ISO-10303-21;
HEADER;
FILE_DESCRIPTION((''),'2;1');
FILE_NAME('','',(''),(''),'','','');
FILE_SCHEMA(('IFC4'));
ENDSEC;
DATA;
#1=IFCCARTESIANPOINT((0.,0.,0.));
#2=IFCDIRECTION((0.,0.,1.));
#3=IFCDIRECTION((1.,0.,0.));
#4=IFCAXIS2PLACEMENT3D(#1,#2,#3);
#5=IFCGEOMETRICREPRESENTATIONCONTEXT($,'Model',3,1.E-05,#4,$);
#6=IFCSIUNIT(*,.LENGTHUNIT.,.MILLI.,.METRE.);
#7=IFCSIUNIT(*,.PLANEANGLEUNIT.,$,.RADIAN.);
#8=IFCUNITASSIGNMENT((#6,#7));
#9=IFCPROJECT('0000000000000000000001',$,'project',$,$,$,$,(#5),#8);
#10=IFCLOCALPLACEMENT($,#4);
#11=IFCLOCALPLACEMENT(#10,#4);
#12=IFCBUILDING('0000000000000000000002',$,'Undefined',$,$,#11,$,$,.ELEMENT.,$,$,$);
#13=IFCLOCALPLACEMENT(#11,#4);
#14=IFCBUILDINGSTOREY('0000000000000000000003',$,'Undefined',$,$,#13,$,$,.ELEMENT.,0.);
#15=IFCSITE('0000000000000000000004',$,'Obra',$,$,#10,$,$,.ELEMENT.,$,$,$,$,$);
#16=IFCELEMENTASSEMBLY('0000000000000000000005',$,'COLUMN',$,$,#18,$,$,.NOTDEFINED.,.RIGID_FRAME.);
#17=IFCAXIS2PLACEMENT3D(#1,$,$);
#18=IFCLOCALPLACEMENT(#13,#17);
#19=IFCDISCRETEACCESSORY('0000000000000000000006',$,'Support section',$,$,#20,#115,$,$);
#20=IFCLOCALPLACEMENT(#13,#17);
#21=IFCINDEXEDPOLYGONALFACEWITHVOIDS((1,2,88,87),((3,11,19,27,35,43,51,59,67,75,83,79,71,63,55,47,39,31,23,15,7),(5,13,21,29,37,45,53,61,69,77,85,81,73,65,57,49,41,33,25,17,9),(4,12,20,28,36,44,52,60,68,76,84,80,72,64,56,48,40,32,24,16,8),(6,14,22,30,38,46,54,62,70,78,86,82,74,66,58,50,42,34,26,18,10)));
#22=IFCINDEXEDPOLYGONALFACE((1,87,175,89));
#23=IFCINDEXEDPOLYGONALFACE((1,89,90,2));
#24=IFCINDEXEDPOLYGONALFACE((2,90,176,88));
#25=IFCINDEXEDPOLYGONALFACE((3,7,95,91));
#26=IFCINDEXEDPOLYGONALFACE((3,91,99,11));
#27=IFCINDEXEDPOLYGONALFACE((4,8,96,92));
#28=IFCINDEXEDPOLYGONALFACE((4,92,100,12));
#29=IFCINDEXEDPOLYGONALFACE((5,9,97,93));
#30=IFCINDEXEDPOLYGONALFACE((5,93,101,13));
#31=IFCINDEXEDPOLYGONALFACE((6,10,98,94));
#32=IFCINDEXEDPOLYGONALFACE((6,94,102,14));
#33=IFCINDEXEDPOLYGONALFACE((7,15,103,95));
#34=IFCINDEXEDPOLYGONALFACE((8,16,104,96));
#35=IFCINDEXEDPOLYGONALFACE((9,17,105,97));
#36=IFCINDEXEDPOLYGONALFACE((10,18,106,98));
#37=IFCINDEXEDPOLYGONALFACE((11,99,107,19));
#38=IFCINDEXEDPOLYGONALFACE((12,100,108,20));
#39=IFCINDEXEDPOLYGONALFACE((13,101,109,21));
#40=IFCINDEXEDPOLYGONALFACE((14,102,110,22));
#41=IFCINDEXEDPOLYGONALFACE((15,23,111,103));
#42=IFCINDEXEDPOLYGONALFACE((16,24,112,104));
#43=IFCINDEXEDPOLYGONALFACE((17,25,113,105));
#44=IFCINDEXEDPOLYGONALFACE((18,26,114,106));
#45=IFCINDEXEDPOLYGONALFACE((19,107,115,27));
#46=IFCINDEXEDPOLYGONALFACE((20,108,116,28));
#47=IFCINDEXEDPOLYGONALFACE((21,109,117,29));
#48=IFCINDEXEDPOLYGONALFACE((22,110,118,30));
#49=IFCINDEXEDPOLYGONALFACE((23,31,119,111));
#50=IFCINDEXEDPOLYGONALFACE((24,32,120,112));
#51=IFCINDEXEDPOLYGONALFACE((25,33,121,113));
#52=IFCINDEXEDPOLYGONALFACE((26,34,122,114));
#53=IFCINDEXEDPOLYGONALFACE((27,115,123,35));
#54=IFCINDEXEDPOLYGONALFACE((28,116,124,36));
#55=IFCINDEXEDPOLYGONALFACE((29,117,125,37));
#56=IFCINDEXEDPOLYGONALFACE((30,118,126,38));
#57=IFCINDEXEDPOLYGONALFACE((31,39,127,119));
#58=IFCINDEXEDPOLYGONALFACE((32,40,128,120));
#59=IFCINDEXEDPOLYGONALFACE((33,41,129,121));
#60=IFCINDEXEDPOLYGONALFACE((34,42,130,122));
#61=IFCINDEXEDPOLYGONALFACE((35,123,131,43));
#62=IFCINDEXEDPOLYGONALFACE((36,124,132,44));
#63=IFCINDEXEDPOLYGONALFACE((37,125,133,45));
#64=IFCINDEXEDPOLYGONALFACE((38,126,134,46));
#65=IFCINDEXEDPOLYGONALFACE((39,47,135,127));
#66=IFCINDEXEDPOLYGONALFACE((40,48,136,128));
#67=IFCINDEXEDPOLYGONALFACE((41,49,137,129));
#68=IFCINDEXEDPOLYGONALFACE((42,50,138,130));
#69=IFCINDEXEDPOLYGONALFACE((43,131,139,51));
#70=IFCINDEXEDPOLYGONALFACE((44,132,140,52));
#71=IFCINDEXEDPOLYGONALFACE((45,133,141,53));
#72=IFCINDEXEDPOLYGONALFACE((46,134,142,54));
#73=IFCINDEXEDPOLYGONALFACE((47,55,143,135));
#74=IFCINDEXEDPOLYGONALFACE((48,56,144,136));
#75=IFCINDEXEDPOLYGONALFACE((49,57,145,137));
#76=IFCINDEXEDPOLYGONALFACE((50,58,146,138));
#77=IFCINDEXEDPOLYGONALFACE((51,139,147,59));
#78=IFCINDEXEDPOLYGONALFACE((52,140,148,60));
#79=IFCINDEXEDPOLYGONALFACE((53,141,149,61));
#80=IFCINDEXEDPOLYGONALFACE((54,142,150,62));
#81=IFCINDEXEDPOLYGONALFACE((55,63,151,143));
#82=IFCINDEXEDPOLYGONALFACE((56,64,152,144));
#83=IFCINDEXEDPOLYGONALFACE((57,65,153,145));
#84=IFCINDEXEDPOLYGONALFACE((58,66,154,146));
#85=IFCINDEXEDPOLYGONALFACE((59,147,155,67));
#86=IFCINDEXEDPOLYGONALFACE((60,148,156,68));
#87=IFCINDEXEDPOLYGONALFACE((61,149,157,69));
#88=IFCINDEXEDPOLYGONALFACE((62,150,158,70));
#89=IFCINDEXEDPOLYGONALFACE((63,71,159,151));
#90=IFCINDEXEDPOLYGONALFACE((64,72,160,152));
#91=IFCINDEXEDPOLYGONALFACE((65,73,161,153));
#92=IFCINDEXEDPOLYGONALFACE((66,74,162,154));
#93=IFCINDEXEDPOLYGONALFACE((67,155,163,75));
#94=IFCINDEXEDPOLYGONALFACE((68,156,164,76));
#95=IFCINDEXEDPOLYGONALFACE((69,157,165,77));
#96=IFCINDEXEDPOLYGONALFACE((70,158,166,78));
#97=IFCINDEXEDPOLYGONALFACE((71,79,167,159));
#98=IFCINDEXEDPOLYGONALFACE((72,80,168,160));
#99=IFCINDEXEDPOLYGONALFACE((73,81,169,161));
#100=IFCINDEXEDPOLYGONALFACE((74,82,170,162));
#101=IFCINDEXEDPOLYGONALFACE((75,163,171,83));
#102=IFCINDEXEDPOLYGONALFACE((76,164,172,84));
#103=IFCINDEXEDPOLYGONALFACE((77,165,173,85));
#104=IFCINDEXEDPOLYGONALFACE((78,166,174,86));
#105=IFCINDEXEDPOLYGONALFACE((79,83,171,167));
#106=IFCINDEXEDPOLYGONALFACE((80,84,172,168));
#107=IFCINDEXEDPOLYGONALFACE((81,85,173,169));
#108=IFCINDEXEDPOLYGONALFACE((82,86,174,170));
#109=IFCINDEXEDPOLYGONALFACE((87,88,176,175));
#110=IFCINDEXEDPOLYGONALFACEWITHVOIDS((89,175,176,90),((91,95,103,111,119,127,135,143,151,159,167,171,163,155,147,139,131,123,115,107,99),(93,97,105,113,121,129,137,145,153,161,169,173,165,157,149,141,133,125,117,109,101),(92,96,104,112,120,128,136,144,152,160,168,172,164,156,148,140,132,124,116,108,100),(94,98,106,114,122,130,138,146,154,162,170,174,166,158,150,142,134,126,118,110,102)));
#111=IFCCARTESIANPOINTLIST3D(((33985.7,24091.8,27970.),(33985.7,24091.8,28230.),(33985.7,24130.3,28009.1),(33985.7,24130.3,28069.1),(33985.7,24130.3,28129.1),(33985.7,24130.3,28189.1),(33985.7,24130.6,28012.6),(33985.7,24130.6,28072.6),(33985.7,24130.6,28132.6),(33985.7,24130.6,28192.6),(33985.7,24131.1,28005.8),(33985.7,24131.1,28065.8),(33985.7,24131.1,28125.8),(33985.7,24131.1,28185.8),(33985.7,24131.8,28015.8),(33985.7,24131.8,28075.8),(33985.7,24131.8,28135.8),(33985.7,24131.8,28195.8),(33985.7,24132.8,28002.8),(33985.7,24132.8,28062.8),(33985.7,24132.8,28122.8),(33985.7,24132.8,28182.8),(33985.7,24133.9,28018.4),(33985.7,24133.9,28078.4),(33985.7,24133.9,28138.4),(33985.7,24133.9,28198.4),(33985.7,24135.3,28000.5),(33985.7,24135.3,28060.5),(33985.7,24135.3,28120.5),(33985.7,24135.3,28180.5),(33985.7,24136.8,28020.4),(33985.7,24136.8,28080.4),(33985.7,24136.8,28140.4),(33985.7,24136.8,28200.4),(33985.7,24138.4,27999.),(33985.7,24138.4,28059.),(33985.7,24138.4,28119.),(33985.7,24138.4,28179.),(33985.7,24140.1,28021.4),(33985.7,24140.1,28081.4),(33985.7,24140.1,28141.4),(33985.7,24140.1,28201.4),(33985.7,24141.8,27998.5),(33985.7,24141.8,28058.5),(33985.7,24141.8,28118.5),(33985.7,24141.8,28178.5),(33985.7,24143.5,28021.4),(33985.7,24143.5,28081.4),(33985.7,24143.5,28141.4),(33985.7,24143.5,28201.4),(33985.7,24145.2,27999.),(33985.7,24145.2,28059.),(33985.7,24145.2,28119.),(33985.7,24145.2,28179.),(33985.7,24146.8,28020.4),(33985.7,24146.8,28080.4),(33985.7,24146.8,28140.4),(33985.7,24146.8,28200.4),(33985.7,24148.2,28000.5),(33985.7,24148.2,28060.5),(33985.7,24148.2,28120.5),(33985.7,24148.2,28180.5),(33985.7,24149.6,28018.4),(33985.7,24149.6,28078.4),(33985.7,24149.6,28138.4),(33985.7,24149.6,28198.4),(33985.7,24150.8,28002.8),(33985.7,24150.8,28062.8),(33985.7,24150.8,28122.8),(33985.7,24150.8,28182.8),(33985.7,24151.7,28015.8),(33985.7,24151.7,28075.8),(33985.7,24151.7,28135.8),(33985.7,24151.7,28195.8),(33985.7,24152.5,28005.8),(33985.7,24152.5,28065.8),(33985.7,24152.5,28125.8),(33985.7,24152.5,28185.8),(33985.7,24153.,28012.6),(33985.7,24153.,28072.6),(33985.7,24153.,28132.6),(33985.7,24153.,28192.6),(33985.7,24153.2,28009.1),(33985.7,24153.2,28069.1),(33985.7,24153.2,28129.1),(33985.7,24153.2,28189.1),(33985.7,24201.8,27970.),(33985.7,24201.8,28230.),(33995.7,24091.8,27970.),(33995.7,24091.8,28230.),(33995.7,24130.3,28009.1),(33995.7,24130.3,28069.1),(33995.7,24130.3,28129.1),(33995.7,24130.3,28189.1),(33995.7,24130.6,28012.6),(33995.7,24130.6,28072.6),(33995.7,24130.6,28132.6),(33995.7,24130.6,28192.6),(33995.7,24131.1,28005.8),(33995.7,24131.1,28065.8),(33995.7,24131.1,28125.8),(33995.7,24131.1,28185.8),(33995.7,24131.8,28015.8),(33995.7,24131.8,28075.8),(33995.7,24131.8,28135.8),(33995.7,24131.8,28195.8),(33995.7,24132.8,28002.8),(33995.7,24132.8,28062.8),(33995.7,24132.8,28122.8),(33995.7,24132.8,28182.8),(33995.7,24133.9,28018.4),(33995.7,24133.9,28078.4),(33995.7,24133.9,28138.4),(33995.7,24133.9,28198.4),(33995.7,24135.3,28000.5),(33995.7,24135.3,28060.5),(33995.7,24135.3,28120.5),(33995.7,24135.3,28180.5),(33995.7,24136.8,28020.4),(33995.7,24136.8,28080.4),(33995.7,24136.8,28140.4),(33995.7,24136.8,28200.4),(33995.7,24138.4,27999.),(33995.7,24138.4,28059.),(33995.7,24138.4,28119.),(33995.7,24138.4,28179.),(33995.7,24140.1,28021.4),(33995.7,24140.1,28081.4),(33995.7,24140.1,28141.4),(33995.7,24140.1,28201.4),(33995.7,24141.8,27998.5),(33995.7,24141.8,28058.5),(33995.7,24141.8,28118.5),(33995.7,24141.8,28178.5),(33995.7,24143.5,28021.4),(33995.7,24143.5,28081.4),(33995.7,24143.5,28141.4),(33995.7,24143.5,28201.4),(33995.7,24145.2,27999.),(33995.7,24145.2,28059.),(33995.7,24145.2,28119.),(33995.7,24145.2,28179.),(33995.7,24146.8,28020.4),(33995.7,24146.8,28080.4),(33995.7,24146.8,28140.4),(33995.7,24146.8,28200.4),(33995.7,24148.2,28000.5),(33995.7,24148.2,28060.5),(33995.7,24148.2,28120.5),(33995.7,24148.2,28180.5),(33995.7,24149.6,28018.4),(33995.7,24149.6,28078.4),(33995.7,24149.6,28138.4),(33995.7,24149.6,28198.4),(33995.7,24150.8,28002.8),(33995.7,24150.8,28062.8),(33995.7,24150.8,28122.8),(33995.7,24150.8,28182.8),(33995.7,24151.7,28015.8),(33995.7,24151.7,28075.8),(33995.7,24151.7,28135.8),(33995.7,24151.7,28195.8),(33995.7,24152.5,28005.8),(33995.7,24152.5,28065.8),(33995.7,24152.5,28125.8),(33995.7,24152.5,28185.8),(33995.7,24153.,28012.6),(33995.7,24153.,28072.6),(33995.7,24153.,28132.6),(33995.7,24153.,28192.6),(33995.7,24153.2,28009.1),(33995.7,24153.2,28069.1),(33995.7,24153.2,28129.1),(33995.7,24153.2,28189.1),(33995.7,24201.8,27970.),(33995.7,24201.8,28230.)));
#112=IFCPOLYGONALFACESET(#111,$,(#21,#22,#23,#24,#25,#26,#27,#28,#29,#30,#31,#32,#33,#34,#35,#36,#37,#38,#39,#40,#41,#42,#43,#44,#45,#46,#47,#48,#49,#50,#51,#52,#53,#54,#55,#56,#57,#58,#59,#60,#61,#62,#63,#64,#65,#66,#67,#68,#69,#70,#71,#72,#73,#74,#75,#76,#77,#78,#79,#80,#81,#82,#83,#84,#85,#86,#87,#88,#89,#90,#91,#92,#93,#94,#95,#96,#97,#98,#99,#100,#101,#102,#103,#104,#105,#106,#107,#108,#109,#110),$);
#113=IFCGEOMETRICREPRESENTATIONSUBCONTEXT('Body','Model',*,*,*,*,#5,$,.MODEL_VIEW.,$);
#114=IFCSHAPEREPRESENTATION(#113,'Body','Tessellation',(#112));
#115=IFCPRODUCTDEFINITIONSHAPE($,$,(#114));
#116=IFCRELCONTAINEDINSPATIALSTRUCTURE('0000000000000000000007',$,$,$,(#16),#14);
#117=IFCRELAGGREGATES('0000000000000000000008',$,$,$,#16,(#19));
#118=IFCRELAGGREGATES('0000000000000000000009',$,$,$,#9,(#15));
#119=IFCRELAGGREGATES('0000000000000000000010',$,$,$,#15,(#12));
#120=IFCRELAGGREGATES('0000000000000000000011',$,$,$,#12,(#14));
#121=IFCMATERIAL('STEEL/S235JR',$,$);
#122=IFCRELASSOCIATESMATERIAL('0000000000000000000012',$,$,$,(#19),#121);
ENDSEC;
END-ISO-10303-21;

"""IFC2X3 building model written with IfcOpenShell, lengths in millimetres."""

from ifc_helpers import new_model, si_unit, frame, origin_with_axes, origin_2d_with_axis, place, context, subcontext, project, spatial, rectangle, circle, extrude, source, transform, mapped, material, element, aggregate, save


model = new_model("IFC2X3")

# Units and contexts
model_context = context("Model", 3, precision=1e-05, world=origin_with_axes())
body_context = subcontext(model_context, "Body", "Model", "MODEL_VIEW")
ifc_project = project(units=[si_unit("LENGTHUNIT", "METRE", prefix="MILLI"), si_unit("PLANEANGLEUNIT", "RADIAN")], contexts=[model_context])

# Site, building, storey
site_placement = place(None, origin_with_axes())
site = spatial("IfcSite", under=ifc_project, at=site_placement, Name="Obra", CompositionType="ELEMENT")
building_placement = place(site_placement, origin_with_axes())
building = spatial("IfcBuilding", under=site, at=building_placement, Name="Undefined", CompositionType="ELEMENT")
storey_placement = place(building_placement, origin_with_axes())
storey = spatial("IfcBuildingStorey", under=building, at=storey_placement, Name="Undefined", CompositionType="ELEMENT", Elevation=0.0)

# Shared definitions
ifc_material_1 = material(Name="STEEL/S235JR")

# Shared definitions
shared_shape_1 = source(origin_with_axes(), body_context, "Body", "SweptSolid", [
    extrude(circle(Radius=11.5, at=origin_2d_with_axis()), frame((0.0, -14.4, 0.0), z_axis=(0.0, 1.0, 0.0), x_axis=(1.0, 0.0, 0.0)), (0.0, 0.0, 1.0), 10.2),
])

# Element assembly, discrete accessory, opening
assembly_1_placement = place(storey_placement, origin_with_axes())
assembly_1 = element("IfcElementAssembly", 1, at=assembly_1_placement, inside=storey, Name="COLUMN", AssemblyPlace="NOTDEFINED", PredefinedType="RIGID_FRAME")
discrete_accessory_1_placement = place(assembly_1_placement, frame((33990.7, 24146.8, 27970.0), z_axis=(0.0, 0.0, 1.0), x_axis=(0.0, 1.0, 0.0)))
discrete_accessory_1 = element("IfcDiscreteAccessory", 2, at=discrete_accessory_1_placement, material=ifc_material_1, Name="Support section", context=body_context, shape_type="SweptSolid", body=[
    extrude(rectangle(XDim=10.0, YDim=110.0, at=origin_2d_with_axis()), frame((0.0, 0.0, 260.0), z_axis=(0.0, 0.0, -1.0), x_axis=(0.0, 1.0, 0.0)), (0.0, 0.0, 1.0), 260.0),
])
opening_1_placement = place(assembly_1_placement, frame((34000.0, 24191.8, 28300.0), z_axis=(0.0, -1.0, 0.0), x_axis=(0.0, 0.0, -1.0)))
element("IfcOpeningElement", 3, at=opening_1_placement, cuts=discrete_accessory_1, ObjectType="Opening", context=body_context, shape_type="MappedRepresentation", body=[
    mapped(shared_shape_1, transform((110.0, 0.0, 50.0))),
    mapped(shared_shape_1, transform((170.0, 0.0, 50.0))),
    mapped(shared_shape_1, transform((230.0, 0.0, 50.0))),
    mapped(shared_shape_1, transform((290.0, 0.0, 50.0))),
])
aggregate(assembly_1, [discrete_accessory_1])

save(model, "model.ifc")
